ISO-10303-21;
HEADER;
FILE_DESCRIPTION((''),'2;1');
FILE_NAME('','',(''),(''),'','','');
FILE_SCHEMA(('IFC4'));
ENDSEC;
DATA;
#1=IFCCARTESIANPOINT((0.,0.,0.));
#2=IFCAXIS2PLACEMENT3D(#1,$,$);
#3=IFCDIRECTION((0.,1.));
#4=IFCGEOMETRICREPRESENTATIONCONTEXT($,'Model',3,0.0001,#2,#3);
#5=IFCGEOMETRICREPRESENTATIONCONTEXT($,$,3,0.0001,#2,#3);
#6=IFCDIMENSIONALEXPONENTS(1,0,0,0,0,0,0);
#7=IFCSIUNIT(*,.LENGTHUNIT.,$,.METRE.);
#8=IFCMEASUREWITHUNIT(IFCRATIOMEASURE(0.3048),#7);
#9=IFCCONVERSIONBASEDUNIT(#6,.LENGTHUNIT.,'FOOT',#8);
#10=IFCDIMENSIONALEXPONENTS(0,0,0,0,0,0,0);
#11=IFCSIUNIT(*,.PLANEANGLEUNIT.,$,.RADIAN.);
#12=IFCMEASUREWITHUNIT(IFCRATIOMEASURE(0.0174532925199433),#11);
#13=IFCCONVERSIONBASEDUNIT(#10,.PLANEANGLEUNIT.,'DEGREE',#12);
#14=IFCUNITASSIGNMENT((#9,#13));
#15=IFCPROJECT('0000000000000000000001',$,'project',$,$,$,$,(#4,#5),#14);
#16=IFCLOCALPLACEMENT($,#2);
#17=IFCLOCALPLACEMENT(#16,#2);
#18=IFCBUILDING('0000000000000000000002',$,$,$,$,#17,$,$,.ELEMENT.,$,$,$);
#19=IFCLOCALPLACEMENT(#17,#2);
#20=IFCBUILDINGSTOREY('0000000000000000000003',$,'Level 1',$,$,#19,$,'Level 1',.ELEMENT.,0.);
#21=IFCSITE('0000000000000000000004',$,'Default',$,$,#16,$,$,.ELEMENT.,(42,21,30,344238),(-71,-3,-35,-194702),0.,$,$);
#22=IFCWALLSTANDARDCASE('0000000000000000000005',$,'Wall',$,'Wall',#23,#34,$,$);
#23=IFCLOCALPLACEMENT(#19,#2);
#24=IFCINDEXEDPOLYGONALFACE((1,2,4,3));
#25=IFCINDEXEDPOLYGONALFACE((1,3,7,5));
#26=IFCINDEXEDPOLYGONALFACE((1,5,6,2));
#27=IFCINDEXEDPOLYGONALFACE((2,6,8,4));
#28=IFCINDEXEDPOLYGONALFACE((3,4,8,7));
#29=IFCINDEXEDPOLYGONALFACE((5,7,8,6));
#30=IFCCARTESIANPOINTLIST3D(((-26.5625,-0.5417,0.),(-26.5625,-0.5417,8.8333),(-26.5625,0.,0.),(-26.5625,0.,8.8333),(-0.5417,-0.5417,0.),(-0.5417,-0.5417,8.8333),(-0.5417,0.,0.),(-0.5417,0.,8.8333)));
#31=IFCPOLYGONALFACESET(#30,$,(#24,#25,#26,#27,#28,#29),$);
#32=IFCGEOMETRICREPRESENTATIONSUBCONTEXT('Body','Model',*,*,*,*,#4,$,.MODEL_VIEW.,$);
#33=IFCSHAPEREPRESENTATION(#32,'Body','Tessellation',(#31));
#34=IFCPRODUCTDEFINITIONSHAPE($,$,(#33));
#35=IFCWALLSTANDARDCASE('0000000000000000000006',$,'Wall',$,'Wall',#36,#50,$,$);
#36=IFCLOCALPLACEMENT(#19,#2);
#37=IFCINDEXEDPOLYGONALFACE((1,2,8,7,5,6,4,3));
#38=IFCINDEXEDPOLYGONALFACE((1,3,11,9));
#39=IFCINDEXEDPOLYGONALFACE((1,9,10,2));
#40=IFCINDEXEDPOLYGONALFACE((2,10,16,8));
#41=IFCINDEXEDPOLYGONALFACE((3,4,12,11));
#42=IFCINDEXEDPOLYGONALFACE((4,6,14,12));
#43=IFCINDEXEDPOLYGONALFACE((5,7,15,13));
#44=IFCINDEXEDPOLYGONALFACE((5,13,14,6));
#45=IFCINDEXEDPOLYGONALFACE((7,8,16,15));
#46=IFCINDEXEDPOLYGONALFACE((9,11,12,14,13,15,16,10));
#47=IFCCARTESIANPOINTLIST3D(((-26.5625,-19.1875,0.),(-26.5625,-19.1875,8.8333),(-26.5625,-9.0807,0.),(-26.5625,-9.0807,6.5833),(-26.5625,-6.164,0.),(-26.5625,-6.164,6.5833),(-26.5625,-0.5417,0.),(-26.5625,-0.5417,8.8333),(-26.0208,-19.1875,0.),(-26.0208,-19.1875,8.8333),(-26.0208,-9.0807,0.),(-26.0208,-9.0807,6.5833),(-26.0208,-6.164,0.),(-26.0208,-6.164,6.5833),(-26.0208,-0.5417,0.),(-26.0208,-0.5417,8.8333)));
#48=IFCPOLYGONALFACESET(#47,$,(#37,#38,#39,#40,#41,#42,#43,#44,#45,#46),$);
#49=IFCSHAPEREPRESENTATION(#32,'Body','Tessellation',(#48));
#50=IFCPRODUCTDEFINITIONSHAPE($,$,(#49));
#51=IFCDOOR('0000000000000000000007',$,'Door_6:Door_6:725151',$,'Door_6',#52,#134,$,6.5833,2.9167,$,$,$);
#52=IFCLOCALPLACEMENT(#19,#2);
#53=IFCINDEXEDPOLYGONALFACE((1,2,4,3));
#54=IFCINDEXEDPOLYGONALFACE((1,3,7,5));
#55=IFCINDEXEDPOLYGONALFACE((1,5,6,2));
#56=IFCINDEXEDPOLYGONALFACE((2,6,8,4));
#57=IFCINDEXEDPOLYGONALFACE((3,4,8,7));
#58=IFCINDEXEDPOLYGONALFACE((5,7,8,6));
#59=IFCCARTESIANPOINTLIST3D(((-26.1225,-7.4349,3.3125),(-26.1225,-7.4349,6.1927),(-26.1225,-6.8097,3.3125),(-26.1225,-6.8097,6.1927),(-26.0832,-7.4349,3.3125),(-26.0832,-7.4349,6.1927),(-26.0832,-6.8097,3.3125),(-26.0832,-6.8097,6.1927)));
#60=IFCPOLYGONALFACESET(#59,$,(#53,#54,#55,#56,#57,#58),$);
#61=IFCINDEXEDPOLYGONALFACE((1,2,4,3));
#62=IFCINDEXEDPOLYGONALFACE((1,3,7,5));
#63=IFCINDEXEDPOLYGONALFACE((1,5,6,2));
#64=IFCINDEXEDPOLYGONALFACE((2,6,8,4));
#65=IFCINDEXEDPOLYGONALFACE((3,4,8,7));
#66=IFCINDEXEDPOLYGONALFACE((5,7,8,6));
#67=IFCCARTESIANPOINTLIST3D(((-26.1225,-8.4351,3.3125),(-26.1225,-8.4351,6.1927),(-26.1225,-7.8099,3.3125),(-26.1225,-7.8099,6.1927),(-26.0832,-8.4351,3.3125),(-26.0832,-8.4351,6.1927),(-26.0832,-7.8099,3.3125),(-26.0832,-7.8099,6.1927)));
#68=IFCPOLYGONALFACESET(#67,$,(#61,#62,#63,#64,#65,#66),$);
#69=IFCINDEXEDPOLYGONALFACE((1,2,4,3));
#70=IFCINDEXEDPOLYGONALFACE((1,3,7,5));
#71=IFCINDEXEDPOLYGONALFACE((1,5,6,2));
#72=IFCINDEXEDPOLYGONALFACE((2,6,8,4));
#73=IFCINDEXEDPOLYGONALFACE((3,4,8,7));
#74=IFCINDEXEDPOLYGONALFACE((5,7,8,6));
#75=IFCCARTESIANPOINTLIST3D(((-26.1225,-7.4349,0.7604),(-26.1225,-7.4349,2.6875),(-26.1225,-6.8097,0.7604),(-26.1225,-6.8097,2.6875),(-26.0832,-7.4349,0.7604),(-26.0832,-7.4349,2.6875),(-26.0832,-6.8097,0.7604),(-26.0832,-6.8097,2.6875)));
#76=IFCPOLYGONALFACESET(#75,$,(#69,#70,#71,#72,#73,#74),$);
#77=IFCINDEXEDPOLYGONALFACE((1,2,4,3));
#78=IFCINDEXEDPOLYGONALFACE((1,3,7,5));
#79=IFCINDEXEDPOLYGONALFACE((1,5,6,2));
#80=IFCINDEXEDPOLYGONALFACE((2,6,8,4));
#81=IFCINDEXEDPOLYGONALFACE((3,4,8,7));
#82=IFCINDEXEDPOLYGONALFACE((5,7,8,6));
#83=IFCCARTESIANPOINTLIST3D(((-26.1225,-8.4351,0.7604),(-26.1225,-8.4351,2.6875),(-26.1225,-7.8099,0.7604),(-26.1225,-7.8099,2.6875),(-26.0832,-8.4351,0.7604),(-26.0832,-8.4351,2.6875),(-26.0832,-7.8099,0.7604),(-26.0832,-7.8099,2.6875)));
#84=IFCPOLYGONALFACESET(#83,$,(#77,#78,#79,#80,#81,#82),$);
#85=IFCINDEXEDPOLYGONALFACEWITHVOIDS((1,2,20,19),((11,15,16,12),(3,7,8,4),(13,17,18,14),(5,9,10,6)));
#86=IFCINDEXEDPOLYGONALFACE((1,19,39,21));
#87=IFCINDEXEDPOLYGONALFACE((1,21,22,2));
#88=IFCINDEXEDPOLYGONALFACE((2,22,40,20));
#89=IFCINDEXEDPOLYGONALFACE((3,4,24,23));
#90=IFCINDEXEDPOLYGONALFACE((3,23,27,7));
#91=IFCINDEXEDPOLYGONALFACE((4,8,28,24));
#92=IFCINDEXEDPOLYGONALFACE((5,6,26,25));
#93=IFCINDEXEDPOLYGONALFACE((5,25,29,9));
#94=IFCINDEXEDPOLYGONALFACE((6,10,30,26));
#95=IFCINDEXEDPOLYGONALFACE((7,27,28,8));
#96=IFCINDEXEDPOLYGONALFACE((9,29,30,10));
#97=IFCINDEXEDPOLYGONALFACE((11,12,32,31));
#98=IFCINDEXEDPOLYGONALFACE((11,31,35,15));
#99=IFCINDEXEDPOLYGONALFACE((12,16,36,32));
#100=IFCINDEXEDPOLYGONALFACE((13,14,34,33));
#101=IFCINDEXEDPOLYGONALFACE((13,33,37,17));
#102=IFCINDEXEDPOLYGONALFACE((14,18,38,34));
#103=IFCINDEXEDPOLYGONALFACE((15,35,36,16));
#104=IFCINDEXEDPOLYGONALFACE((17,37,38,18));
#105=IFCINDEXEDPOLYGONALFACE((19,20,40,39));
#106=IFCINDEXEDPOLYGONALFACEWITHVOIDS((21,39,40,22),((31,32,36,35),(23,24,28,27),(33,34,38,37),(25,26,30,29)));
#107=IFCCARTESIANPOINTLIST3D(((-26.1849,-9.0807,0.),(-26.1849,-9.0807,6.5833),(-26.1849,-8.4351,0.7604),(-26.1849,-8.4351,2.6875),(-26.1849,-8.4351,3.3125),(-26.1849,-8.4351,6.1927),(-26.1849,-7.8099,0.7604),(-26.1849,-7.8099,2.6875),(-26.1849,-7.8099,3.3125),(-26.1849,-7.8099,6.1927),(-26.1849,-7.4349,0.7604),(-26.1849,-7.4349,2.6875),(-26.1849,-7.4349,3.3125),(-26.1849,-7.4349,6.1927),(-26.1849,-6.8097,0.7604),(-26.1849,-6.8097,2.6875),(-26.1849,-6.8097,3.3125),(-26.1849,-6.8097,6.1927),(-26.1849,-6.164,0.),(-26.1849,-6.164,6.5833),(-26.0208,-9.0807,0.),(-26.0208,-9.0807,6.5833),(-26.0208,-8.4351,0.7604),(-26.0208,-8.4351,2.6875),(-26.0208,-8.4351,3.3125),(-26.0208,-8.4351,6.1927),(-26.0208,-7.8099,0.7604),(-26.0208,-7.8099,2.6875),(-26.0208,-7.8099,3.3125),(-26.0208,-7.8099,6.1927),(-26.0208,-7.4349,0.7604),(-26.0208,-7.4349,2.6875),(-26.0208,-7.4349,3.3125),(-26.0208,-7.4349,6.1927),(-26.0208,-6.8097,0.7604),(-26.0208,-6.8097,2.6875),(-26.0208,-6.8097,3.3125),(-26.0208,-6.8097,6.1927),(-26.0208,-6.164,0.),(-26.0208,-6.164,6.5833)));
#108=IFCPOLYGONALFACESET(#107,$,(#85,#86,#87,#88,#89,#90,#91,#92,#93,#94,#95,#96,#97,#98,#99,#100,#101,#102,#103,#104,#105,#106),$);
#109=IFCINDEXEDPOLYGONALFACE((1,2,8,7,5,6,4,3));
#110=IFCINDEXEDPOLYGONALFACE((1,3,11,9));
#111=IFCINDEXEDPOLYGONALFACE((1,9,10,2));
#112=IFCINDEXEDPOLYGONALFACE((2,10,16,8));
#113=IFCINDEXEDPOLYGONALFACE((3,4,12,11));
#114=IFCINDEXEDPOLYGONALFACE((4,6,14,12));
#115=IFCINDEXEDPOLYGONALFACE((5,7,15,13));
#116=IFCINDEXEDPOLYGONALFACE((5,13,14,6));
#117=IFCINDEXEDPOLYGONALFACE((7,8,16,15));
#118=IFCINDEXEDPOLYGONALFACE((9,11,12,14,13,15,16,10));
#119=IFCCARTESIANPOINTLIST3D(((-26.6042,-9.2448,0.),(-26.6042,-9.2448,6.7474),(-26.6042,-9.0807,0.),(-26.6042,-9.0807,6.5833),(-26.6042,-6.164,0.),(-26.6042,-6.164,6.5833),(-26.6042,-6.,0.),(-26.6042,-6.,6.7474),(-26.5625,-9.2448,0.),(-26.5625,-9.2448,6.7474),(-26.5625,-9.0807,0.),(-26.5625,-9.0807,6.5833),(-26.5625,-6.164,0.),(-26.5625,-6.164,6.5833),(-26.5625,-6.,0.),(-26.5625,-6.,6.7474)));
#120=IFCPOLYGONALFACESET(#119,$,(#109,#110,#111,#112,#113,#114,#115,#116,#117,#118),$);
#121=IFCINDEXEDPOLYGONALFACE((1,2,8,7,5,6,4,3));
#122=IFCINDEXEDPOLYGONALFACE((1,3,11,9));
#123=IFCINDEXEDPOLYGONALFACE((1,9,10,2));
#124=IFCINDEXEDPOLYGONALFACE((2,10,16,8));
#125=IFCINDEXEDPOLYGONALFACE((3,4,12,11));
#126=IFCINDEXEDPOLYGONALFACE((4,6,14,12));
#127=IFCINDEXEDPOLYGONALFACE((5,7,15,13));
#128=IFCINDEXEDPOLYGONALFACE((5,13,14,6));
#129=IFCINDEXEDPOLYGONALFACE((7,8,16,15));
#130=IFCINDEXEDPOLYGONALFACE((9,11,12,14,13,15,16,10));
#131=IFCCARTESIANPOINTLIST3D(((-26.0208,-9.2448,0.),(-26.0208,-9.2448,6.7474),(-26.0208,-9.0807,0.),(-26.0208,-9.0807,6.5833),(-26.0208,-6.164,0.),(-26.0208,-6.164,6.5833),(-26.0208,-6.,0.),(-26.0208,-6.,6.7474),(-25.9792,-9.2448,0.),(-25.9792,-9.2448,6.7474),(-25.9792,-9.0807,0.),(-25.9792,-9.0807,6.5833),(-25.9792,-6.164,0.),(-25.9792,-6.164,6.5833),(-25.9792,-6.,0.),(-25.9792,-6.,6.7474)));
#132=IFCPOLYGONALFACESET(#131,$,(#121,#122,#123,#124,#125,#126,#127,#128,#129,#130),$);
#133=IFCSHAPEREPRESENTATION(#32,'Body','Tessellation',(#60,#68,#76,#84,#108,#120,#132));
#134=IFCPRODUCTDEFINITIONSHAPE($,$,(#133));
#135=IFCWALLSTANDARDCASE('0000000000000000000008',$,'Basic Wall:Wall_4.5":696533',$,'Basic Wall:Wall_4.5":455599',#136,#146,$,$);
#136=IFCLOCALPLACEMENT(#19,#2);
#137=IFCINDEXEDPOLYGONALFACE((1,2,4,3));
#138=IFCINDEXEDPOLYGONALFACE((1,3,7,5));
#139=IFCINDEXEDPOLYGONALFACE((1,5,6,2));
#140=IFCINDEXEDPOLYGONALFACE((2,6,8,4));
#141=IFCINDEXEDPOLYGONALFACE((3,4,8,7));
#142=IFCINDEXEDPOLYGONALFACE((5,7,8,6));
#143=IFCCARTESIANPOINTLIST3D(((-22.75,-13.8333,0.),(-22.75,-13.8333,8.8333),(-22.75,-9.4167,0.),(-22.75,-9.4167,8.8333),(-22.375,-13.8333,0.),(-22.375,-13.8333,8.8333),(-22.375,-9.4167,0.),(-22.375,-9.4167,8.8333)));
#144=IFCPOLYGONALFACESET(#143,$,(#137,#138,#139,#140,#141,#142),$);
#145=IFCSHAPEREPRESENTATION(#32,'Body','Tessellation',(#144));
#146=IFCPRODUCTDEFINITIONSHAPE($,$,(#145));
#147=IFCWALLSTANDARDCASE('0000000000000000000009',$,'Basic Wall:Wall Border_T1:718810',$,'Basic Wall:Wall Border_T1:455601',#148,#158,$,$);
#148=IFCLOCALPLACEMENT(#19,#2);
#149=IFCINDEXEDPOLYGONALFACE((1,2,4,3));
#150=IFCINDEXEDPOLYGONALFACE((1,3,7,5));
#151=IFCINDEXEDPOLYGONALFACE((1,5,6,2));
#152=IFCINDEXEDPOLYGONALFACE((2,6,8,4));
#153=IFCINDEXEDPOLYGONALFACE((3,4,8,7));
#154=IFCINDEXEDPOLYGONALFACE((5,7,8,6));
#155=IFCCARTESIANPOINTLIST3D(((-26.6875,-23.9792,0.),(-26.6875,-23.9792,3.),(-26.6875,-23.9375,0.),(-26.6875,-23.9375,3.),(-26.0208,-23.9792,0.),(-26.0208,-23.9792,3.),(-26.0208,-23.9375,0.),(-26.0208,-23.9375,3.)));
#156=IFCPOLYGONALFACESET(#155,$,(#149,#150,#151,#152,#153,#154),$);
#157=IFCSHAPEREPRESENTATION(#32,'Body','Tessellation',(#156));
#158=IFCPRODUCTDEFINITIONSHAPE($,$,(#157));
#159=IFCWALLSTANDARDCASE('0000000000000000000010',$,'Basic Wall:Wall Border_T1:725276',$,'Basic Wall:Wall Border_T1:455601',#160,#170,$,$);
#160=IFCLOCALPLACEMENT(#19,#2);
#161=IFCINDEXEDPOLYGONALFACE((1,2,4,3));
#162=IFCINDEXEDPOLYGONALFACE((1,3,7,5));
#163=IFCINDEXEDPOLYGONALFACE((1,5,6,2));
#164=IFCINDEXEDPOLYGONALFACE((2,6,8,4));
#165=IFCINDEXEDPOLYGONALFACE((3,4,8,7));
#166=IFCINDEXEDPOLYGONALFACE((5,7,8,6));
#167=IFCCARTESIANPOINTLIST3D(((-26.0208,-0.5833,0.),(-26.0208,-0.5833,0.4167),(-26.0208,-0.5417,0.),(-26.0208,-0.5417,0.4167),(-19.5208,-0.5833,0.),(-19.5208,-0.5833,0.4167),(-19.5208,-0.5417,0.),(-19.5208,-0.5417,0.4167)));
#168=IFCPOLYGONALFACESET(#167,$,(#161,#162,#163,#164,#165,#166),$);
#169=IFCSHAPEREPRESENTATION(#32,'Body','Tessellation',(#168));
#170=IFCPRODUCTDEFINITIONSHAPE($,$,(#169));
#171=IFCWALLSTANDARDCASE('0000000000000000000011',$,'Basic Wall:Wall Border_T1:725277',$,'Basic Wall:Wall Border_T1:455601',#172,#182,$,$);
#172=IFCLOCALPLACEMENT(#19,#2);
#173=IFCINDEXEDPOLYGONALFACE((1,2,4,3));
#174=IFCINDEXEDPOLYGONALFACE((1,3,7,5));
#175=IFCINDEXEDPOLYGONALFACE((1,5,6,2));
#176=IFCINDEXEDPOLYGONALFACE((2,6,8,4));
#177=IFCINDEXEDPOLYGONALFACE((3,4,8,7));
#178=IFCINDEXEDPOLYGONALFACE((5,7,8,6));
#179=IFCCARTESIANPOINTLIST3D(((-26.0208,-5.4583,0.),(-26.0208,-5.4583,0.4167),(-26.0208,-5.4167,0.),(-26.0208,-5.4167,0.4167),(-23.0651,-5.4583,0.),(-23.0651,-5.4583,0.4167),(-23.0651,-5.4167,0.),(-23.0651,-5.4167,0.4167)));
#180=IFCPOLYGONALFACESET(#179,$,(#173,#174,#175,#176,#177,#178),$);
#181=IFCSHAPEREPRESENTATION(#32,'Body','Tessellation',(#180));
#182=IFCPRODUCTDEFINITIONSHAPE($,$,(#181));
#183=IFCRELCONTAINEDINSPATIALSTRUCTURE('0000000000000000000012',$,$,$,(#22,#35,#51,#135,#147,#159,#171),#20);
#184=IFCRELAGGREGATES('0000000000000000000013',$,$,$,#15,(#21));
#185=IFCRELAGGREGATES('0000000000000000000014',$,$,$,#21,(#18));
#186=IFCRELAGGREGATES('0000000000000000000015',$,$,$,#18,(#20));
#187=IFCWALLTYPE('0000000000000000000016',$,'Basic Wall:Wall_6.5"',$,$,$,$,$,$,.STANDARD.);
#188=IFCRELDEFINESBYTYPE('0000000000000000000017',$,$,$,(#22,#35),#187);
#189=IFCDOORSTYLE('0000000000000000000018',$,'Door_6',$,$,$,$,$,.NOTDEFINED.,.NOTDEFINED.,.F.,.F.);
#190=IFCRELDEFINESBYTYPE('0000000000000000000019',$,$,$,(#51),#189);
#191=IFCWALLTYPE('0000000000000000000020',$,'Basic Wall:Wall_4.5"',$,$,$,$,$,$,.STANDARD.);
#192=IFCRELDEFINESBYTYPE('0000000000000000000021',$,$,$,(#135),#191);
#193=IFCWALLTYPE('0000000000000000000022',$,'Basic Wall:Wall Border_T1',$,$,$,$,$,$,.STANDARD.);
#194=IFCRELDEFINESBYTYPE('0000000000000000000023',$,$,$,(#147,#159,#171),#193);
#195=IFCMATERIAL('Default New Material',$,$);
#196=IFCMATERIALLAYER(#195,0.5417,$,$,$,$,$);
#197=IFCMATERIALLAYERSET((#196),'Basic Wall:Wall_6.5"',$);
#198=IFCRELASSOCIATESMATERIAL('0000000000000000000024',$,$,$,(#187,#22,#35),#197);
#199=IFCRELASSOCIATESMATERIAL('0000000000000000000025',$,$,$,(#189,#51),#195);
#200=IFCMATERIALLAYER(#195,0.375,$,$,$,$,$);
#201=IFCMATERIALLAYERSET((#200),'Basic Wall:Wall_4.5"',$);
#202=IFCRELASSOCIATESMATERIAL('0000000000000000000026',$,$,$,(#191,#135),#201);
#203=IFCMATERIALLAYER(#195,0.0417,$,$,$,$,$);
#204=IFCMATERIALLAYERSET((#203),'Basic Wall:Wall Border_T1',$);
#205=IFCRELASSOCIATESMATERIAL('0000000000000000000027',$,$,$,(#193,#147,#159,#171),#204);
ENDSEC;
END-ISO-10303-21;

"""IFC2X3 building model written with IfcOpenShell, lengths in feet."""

from ifc_helpers import new_model, entity, si_unit, converted_unit, direction, frame, frame_2d, origin, place, context, subcontext, project, spatial, polyline, rectangle, outline, extrude, source, transform, mapped, material, layer, layer_set, layer_usage, type_object, type_shapes, element, fill, save


model = new_model("IFC2X3")

# Units and contexts
model_context = context("Model", 3, precision=0.0001, world=origin(), true_north=direction((0.0, 1.0)))
context_of_model = context(None, 3, precision=0.0001, world=origin(), true_north=direction((0.0, 1.0)))
body_context = subcontext(model_context, "Body", "Model", "MODEL_VIEW")
ifc_project = project(units=[converted_unit("LENGTHUNIT", "FOOT", entity("IfcRatioMeasure", 0.3048), si_unit("LENGTHUNIT", "METRE"), dimensions=[1, 0, 0, 0, 0, 0, 0]), converted_unit("PLANEANGLEUNIT", "DEGREE", entity("IfcRatioMeasure", 0.0174532925199433), si_unit("PLANEANGLEUNIT", "RADIAN"), dimensions=[0, 0, 0, 0, 0, 0, 0])], contexts=[model_context, context_of_model])

# Site, building, storey
site_placement = place(None, origin())
site = spatial("IfcSite", under=ifc_project, at=site_placement, Name="Default", CompositionType="ELEMENT", RefLatitude=(42, 21, 30, 344238), RefLongitude=(-71, -3, -35, -194702), RefElevation=0.0)
building_placement = place(site_placement, origin())
building = spatial("IfcBuilding", under=site, at=building_placement, CompositionType="ELEMENT")
storey_placement = place(building_placement, origin())
storey = spatial("IfcBuildingStorey", under=building, at=storey_placement, Name="Level 1", LongName="Level 1", CompositionType="ELEMENT", Elevation=0.0)

# Wall
ifc_material = material(Name="Default New Material")
ifc_layer_1 = layer(ifc_material, 0.5417)
ifc_layer_set_1 = layer_set([ifc_layer_1], Name="Basic Wall:Wall_6.5\"")
ifc_layer_usage_1 = layer_usage(ifc_layer_set_1, "AXIS2", "NEGATIVE", 0.2708)
wall_type_1 = type_object("IfcWallType", Name="Basic Wall:Wall_6.5\"", PredefinedType="STANDARD", material=ifc_layer_set_1)
wall_1_placement = place(storey_placement, frame((-26.5625, -0.2708, 0.0)))
element("IfcWallStandardCase", 1, at=wall_1_placement, inside=storey, type_object=wall_type_1, material=ifc_layer_usage_1, Name="Wall", ObjectType="Wall", context=body_context, shape_type="SweptSolid", body=[
    extrude(rectangle(XDim=26.0208, YDim=0.5417, at=frame_2d((13.0104, 0.0), x_axis=(-1.0, 0.0))), origin(), (0.0, 0.0, 1.0), 8.8333),
])

# Wall, opening, door
ifc_layer_usage_2 = layer_usage(ifc_layer_set_1, "AXIS2", "NEGATIVE", 0.2708)
wall_2_placement = place(storey_placement, frame((-26.2917, -19.1875, 0.0), z_axis=(0.0, 0.0, 1.0), x_axis=(0.0, 1.0, 0.0)))
wall_2 = element("IfcWallStandardCase", 2, at=wall_2_placement, inside=storey, type_object=wall_type_1, material=ifc_layer_usage_2, Name="Wall", ObjectType="Wall", context=body_context, shape_type="SweptSolid", body=[
    extrude(rectangle(XDim=18.6458, YDim=0.5417, at=frame_2d((9.3229, 0.0), x_axis=(-1.0, 0.0))), origin(), (0.0, 0.0, 1.0), 8.8333),
])
opening_1_placement = place(wall_2_placement, frame((13.0235, 0.2708, 0.0)))
opening_1 = element("IfcOpeningElement", 3, at=opening_1_placement, cuts=wall_2, ObjectType="Opening", context=body_context, shape_type="SweptSolid", body=[
    extrude(rectangle(XDim=6.5833, YDim=2.9167, at=frame_2d((3.2917, 1.4583), x_axis=(1.0, 0.0))), frame((0.0, 0.0, 0.0), z_axis=(0.0, -1.0, 0.0), x_axis=(0.0, 0.0, 1.0)), (0.0, 0.0, 1.0), 0.5417),
])
door_style_1 = type_object("IfcDoorStyle", Name="Door_6", ConstructionType="NOTDEFINED", OperationType="NOTDEFINED", ParameterTakesPrecedence=False, Sizeable=False, material=ifc_material)
shared_shape_1 = source(origin(), body_context, "Body", "SweptSolid", [
    extrude(rectangle(XDim=0.6252, YDim=0.0394, at=frame_2d((0.0, 0.0), x_axis=(1.0, 0.0))), frame((0.9582, 0.4388, 3.3125)), (0.0, 0.0, 1.0), 2.8802),
    extrude(rectangle(XDim=0.6252, YDim=0.0394, at=frame_2d((0.0, 0.0), x_axis=(1.0, 0.0))), frame((1.9584, 0.4388, 3.3125)), (0.0, 0.0, 1.0), 2.8802),
    extrude(rectangle(XDim=0.6252, YDim=0.0394, at=frame_2d((0.0, 0.0), x_axis=(1.0, 0.0))), frame((0.9582, 0.4388, 0.7604)), (0.0, 0.0, 1.0), 1.9271),
    extrude(rectangle(XDim=0.6252, YDim=0.0394, at=frame_2d((0.0, 0.0), x_axis=(1.0, 0.0))), frame((1.9584, 0.4388, 0.7604)), (0.0, 0.0, 1.0), 1.9271),
    extrude(outline(polyline([(-1.4583, -3.2917), (1.4583, -3.2917), (1.4583, 3.2917), (-1.4583, 3.2917), (-1.4583, -3.2917)]), holes=[polyline([(0.8127, -2.901), (0.1875, -2.901), (0.1875, -0.0208), (0.8127, -0.0208), (0.8127, -2.901)]), polyline([(-0.1875, -0.0208), (-0.1875, -2.901), (-0.8127, -2.901), (-0.8127, -0.0208), (-0.1875, -0.0208)]), polyline([(0.1875, 0.6042), (0.1875, 2.5312), (0.8127, 2.5312), (0.8127, 0.6042), (0.1875, 0.6042)]), polyline([(-0.1875, 2.5312), (-0.1875, 0.6042), (-0.8127, 0.6042), (-0.8127, 2.5312), (-0.1875, 2.5312)])]), frame((1.4583, 0.5208, 3.2917), z_axis=(0.0, -1.0, 0.0), x_axis=(-1.0, 0.0, 0.0)), (0.0, 0.0, 1.0), 0.164),
    extrude(outline(polyline([(-3.2507, 1.4583), (3.3327, 1.4583), (3.3327, 1.6224), (-3.4147, 1.6224), (-3.4147, -1.6224), (3.3327, -1.6224), (3.3327, -1.4583), (-3.2507, -1.4583), (-3.2507, 1.4583)])), frame((1.4583, -0.0208, 3.3327), z_axis=(0.0, -1.0, 0.0), x_axis=(0.0, 0.0, -1.0)), (0.0, 0.0, 1.0), 0.0417),
    extrude(outline(polyline([(-3.2507, 1.4583), (3.3327, 1.4583), (3.3327, 1.6224), (-3.4147, 1.6224), (-3.4147, -1.6224), (3.3327, -1.6224), (3.3327, -1.4583), (-3.2507, -1.4583), (-3.2507, 1.4583)])), frame((1.4583, 0.5625, 3.3327), z_axis=(0.0, -1.0, 0.0), x_axis=(0.0, 0.0, -1.0)), (0.0, 0.0, 1.0), 0.0417),
])
type_shapes(door_style_1, [shared_shape_1])
door_1_placement = place(opening_1_placement, frame((0.0, -0.0208, 0.0), z_axis=(0.0, 0.0, 1.0), x_axis=(-1.0, 0.0, 0.0)))
door_1 = element("IfcDoor", 4, at=door_1_placement, inside=storey, type_object=door_style_1, material=ifc_material, Name="Door_6:Door_6:725151", ObjectType="Door_6", OverallHeight=6.5833, OverallWidth=2.9167, context=body_context, shape_type="MappedRepresentation", body=[
    mapped(shared_shape_1, transform((0.0, 0.0, 0.0), scale=1.0)),
])
fill(opening_1, door_1)

# Wall
ifc_layer_2 = layer(ifc_material, 0.375)
ifc_layer_set_2 = layer_set([ifc_layer_2], Name="Basic Wall:Wall_4.5\"")
ifc_layer_usage_3 = layer_usage(ifc_layer_set_2, "AXIS2", "NEGATIVE", 0.1875)
wall_type_2 = type_object("IfcWallType", Name="Basic Wall:Wall_4.5\"", PredefinedType="STANDARD", material=ifc_layer_set_2)
wall_3_placement = place(storey_placement, frame((-22.5625, -13.8333, 0.0), z_axis=(0.0, 0.0, 1.0), x_axis=(0.0, 1.0, 0.0)))
element("IfcWallStandardCase", 5, at=wall_3_placement, inside=storey, type_object=wall_type_2, material=ifc_layer_usage_3, Name="Basic Wall:Wall_4.5\":696533", ObjectType="Basic Wall:Wall_4.5\":455599", context=body_context, shape_type="SweptSolid", body=[
    extrude(rectangle(XDim=4.4167, YDim=0.375, at=frame_2d((2.2083, 0.0), x_axis=(-1.0, 0.0))), origin(), (0.0, 0.0, 1.0), 8.8333),
])

# Walls
ifc_layer_3 = layer(ifc_material, 0.0417)
ifc_layer_set_3 = layer_set([ifc_layer_3], Name="Basic Wall:Wall Border_T1")
ifc_layer_usage_4 = layer_usage(ifc_layer_set_3, "AXIS2", "POSITIVE", -0.0208)
wall_type_3 = type_object("IfcWallType", Name="Basic Wall:Wall Border_T1", PredefinedType="STANDARD", material=ifc_layer_set_3)
wall_4_placement = place(storey_placement, frame((-26.0208, -23.9583, 0.0), z_axis=(0.0, 0.0, 1.0), x_axis=(-1.0, 0.0, 0.0)))
element("IfcWallStandardCase", 6, at=wall_4_placement, inside=storey, type_object=wall_type_3, material=ifc_layer_usage_4, Name="Basic Wall:Wall Border_T1:718810", ObjectType="Basic Wall:Wall Border_T1:455601", context=body_context, shape_type="SweptSolid", body=[
    extrude(rectangle(XDim=0.6667, YDim=0.0417, at=frame_2d((0.3333, 0.0), x_axis=(-1.0, 0.0))), origin(), (0.0, 0.0, 1.0), 3.0),
])
ifc_layer_usage_5 = layer_usage(ifc_layer_set_3, "AXIS2", "POSITIVE", -0.0208)
wall_5_placement = place(storey_placement, frame((-26.0208, -0.5625, 0.0)))
element("IfcWallStandardCase", 7, at=wall_5_placement, inside=storey, type_object=wall_type_3, material=ifc_layer_usage_5, Name="Basic Wall:Wall Border_T1:725276", ObjectType="Basic Wall:Wall Border_T1:455601", context=body_context, shape_type="SweptSolid", body=[
    extrude(rectangle(XDim=6.5, YDim=0.0417, at=frame_2d((3.25, 0.0), x_axis=(-1.0, 0.0))), origin(), (0.0, 0.0, 1.0), 0.4167),
])
ifc_layer_usage_6 = layer_usage(ifc_layer_set_3, "AXIS2", "POSITIVE", -0.0208)
wall_6_placement = place(storey_placement, frame((-23.0651, -5.4375, 0.0), z_axis=(0.0, 0.0, 1.0), x_axis=(-1.0, 0.0, 0.0)))
element("IfcWallStandardCase", 8, at=wall_6_placement, inside=storey, type_object=wall_type_3, material=ifc_layer_usage_6, Name="Basic Wall:Wall Border_T1:725277", ObjectType="Basic Wall:Wall Border_T1:455601", context=body_context, shape_type="SweptSolid", body=[
    extrude(rectangle(XDim=2.9557, YDim=0.0417, at=frame_2d((1.4779, 0.0), x_axis=(-1.0, 0.0))), origin(), (0.0, 0.0, 1.0), 0.4167),
])

save(model, "model.ifc")
